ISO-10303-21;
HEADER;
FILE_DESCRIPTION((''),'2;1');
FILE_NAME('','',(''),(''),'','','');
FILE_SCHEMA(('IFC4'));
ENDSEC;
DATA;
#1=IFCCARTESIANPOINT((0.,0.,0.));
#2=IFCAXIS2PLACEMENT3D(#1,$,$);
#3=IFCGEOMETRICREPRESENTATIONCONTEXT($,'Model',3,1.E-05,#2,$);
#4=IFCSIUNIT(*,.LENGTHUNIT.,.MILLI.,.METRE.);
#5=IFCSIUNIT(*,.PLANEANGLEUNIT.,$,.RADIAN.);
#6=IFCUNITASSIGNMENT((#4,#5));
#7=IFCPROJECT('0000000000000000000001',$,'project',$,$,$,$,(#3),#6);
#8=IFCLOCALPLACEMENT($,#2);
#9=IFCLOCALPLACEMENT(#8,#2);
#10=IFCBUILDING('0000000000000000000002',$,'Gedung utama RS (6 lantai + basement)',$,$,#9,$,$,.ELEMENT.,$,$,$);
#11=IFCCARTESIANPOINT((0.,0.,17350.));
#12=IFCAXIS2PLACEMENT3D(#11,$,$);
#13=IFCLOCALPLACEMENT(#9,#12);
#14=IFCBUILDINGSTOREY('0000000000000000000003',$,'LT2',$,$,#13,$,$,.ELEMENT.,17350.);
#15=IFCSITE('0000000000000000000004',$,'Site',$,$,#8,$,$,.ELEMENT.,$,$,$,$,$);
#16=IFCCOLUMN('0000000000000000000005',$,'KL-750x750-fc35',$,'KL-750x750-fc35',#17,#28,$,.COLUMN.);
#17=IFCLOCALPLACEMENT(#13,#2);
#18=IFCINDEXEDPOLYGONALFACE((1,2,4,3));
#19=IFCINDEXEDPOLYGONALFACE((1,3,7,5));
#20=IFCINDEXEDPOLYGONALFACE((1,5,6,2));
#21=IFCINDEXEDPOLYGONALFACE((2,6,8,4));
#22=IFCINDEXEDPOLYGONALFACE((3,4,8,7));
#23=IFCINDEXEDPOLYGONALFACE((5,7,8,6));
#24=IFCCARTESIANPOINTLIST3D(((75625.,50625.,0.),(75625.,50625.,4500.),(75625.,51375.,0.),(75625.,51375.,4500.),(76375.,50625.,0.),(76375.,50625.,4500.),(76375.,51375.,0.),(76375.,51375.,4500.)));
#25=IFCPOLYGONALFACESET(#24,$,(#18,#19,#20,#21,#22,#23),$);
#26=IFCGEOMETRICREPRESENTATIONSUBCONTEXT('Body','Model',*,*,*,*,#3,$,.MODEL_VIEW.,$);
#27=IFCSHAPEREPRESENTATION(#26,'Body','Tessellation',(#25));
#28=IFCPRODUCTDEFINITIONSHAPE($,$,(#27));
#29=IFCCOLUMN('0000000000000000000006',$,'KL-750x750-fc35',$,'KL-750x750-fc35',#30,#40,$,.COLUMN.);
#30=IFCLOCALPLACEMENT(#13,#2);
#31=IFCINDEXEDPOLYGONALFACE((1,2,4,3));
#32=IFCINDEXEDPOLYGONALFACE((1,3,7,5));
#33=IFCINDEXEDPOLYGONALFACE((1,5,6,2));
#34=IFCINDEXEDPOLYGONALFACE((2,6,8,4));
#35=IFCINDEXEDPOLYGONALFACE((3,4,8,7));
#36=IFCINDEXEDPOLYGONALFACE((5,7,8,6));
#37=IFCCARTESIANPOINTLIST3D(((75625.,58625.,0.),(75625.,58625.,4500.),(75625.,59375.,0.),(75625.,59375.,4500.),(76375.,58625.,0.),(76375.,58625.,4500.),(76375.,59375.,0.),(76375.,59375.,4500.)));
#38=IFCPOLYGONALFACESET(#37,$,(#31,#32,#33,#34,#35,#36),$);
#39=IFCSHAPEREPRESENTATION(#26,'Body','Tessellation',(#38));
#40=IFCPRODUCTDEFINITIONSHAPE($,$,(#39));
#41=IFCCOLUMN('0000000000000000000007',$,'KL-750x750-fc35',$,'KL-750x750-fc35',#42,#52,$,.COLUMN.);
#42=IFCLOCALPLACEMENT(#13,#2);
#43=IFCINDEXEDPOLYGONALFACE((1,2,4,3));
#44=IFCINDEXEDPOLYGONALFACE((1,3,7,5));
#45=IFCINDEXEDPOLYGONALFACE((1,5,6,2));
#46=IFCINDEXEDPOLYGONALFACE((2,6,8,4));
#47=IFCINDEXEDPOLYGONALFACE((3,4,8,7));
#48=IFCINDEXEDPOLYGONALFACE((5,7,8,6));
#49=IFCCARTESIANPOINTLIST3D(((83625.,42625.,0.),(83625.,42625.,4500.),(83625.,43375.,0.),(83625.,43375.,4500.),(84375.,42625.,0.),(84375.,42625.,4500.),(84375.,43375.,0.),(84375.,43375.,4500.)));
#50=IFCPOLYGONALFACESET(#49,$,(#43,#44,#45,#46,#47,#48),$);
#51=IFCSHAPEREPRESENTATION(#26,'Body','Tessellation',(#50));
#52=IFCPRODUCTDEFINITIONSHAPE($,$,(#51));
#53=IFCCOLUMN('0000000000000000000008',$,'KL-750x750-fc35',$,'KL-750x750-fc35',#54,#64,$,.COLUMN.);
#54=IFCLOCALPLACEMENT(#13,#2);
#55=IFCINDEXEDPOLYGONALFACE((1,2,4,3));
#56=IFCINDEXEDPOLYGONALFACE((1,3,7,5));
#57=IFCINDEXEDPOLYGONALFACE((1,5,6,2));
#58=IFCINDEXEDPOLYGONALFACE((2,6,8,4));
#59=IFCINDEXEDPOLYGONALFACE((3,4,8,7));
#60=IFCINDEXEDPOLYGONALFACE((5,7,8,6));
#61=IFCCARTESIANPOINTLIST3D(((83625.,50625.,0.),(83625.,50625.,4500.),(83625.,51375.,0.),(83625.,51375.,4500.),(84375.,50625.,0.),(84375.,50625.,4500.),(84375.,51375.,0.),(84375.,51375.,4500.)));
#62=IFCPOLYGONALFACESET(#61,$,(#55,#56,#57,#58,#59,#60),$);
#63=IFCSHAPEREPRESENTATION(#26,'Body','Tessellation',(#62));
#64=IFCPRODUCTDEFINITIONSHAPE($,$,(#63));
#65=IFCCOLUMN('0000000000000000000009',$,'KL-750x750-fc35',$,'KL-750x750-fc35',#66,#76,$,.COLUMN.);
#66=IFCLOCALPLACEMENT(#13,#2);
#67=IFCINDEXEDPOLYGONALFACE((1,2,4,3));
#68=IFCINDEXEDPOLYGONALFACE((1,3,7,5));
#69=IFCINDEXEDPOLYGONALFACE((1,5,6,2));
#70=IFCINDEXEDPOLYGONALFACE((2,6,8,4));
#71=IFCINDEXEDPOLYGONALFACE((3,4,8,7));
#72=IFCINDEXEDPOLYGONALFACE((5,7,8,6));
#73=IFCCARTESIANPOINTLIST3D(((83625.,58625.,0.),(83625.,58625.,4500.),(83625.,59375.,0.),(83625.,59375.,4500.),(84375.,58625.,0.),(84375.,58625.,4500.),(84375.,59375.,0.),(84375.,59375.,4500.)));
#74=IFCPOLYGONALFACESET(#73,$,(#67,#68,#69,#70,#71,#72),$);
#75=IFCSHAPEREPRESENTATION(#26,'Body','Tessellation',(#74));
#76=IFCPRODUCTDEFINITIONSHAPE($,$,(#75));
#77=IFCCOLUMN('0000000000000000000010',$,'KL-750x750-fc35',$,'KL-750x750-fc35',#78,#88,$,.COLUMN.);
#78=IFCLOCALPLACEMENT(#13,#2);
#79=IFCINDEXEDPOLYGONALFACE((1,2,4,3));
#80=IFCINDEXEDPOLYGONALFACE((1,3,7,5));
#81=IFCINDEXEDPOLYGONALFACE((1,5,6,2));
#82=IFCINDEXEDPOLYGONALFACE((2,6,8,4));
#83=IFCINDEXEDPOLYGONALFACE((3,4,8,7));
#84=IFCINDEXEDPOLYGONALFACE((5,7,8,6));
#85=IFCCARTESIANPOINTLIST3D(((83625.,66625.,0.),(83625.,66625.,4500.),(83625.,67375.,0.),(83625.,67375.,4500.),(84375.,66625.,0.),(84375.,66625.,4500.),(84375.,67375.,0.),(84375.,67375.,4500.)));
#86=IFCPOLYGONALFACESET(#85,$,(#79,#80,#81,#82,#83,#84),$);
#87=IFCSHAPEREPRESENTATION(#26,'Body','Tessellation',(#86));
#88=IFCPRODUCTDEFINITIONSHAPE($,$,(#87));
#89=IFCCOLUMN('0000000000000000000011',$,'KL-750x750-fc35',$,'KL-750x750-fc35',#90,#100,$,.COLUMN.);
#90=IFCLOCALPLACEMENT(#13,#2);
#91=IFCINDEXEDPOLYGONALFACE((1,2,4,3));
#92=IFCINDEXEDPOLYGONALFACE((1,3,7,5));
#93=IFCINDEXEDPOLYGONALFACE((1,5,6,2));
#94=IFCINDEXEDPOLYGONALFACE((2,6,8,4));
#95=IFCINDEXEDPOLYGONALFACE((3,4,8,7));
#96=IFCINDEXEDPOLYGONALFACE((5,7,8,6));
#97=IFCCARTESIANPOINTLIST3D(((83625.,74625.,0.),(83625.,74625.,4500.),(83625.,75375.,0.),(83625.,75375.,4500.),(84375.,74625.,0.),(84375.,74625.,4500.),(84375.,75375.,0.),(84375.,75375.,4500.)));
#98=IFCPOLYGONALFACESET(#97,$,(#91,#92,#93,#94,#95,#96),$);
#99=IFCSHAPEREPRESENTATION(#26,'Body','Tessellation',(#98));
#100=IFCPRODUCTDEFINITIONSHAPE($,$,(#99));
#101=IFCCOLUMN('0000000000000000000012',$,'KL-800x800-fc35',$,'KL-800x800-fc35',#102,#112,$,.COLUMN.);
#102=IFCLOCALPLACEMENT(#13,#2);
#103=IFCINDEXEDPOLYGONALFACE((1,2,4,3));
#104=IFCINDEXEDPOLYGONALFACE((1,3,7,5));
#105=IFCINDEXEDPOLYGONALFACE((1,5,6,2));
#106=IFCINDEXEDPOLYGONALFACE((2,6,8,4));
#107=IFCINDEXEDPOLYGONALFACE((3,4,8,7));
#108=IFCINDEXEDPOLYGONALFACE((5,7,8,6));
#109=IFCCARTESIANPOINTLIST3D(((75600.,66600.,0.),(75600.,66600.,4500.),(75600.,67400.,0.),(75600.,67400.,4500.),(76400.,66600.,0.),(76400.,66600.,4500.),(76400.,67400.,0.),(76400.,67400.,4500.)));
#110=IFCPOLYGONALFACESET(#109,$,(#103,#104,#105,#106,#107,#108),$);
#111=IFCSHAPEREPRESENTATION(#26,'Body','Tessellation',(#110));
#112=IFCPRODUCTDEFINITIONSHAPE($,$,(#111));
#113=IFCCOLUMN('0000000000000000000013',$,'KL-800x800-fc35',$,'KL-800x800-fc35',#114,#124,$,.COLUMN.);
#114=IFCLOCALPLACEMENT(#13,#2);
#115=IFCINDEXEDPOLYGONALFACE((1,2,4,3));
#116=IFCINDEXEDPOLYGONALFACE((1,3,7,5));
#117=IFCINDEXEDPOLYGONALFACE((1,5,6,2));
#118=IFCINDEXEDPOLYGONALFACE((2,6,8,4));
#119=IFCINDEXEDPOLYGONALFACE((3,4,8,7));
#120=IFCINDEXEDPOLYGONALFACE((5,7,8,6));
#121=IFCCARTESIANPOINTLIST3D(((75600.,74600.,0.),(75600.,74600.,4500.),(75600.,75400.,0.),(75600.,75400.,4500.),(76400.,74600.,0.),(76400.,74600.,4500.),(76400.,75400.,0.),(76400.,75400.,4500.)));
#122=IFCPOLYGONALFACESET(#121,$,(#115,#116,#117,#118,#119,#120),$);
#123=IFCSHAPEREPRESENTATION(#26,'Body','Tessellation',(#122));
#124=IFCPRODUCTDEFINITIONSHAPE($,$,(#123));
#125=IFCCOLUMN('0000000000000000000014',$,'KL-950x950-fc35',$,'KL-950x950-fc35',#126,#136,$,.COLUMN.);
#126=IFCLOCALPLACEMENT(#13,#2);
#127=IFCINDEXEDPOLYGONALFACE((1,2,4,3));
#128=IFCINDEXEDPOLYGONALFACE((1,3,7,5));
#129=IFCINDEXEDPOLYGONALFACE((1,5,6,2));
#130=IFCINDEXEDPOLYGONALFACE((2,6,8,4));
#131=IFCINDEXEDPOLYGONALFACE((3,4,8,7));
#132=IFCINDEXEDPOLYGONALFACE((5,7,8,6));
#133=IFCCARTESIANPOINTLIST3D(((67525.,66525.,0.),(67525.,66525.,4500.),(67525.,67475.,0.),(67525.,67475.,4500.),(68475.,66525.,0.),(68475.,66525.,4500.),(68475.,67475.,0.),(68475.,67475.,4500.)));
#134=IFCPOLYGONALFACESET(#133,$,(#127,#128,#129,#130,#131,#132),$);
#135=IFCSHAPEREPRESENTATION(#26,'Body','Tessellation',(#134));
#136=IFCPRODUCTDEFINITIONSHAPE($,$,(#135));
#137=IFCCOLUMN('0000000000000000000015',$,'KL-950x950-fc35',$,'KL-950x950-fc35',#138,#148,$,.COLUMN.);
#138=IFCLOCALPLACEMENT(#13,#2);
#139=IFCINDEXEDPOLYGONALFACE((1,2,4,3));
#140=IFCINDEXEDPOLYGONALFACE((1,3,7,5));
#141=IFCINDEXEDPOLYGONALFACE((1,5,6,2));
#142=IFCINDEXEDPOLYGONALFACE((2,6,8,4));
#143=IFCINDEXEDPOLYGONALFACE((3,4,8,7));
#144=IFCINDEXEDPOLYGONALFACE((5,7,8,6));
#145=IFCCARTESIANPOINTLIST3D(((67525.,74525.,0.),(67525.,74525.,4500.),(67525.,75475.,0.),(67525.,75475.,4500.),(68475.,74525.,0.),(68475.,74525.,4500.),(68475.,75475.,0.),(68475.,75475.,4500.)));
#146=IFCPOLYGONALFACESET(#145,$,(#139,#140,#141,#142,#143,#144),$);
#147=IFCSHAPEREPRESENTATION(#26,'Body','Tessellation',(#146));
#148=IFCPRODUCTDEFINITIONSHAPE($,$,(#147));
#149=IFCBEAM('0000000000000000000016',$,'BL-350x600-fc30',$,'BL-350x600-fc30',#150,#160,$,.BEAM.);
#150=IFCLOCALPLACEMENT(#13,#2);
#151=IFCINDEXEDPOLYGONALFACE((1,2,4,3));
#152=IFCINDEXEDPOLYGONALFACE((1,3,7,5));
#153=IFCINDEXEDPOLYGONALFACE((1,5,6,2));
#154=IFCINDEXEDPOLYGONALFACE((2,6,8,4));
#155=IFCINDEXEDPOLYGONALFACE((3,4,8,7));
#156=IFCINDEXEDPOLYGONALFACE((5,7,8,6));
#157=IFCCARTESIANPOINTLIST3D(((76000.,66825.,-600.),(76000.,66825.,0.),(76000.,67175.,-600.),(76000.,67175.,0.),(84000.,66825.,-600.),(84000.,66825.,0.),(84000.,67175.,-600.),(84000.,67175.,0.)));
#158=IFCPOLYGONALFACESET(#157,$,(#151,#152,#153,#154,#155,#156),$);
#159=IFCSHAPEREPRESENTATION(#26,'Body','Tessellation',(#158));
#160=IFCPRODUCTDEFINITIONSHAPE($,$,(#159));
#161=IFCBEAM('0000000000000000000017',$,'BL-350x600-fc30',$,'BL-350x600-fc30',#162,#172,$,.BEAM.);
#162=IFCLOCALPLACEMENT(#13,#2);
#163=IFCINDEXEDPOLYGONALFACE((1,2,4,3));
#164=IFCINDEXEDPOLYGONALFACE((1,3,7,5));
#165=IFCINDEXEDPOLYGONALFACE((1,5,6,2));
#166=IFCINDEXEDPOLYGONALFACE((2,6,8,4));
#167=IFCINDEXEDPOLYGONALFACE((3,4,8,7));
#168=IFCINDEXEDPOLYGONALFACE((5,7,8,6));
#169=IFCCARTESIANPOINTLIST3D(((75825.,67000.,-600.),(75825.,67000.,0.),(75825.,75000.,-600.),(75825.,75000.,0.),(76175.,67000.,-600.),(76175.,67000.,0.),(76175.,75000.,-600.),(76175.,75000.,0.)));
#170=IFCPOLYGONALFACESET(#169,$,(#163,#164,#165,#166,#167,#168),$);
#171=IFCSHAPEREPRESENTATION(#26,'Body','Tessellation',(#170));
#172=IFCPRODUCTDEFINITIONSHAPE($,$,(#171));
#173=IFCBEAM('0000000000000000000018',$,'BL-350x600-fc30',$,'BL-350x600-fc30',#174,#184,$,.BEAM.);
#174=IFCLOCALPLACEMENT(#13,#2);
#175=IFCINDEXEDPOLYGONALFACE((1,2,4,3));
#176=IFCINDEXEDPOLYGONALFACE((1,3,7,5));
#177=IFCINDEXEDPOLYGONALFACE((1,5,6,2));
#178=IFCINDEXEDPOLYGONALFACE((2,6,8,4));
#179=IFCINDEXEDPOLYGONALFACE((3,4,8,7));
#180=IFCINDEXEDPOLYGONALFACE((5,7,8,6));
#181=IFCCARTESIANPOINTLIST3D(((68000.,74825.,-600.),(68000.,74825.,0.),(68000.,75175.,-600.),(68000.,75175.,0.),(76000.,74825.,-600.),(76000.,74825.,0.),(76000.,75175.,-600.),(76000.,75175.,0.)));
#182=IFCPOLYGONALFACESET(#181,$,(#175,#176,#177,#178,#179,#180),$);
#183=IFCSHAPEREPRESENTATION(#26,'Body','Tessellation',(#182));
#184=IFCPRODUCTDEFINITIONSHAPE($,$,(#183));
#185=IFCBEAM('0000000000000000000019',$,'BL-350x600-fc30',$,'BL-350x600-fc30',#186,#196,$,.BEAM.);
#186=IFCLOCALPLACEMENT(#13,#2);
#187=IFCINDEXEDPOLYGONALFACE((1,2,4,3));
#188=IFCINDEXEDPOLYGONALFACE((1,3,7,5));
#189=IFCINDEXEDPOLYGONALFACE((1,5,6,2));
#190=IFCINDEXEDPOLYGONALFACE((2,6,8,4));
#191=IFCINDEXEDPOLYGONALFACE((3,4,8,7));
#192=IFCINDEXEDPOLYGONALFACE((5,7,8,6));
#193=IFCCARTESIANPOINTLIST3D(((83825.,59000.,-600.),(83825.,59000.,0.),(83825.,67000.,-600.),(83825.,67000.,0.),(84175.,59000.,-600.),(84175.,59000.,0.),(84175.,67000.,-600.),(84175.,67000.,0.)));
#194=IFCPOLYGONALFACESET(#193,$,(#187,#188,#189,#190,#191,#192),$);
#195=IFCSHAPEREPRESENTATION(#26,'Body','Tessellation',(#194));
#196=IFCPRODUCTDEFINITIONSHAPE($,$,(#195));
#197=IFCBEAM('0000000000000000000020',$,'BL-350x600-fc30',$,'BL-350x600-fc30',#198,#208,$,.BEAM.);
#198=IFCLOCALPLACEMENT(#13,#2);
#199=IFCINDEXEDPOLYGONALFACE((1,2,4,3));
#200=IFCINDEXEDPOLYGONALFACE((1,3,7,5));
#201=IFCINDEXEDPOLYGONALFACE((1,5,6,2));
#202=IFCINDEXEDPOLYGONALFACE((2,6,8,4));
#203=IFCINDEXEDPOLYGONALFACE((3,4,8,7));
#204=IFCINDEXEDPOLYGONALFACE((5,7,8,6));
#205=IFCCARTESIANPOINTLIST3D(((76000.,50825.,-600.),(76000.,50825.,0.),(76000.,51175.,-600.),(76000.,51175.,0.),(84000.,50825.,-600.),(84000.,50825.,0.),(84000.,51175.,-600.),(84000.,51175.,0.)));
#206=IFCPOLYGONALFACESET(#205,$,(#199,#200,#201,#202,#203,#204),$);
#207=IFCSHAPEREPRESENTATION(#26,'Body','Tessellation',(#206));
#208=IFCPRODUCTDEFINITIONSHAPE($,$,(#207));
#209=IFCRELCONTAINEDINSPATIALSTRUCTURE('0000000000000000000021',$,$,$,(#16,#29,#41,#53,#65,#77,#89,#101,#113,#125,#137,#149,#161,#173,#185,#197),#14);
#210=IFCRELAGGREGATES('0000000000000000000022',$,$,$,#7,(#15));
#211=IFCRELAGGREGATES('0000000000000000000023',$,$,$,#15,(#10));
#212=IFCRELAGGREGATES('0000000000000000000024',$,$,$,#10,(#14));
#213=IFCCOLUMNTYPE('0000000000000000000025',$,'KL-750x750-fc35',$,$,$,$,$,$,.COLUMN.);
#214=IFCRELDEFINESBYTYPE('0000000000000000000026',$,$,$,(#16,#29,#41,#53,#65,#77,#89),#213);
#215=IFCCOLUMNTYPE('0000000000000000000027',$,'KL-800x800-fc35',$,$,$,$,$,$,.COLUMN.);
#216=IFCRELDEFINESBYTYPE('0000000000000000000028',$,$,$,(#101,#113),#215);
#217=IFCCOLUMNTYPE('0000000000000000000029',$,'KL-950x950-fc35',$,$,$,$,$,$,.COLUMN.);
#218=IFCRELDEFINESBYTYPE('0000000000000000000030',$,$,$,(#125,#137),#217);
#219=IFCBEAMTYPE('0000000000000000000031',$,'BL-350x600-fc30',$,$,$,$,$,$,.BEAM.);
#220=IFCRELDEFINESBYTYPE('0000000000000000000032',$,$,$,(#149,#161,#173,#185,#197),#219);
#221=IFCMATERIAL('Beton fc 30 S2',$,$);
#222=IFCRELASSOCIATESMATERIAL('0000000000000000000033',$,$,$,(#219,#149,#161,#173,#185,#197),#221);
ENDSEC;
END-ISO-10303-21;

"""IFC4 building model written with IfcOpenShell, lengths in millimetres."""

from ifc_helpers import new_model, si_unit, frame, origin, origin_2d, place, context, subcontext, project, spatial, rectangle, extrude, material, material_profile, profile_set, profile_usage, type_object, element, save


model = new_model("IFC4")

# Units and contexts
model_context = context("Model", 3, precision=1e-05, world=origin())
body_context = subcontext(model_context, "Body", "Model", "MODEL_VIEW")
ifc_project = project(units=[si_unit("LENGTHUNIT", "METRE", prefix="MILLI"), si_unit("PLANEANGLEUNIT", "RADIAN")], contexts=[model_context])

# Site, building, storey
site_placement = place(None, origin())
site = spatial("IfcSite", under=ifc_project, at=site_placement, Name="Site", CompositionType="ELEMENT")
building_placement = place(site_placement, origin())
building = spatial("IfcBuilding", under=site, at=building_placement, Name="Gedung utama RS (6 lantai + basement)", CompositionType="ELEMENT")
storey_placement = place(building_placement, frame((0.0, 0.0, 17350.0)))
storey = spatial("IfcBuildingStorey", under=building, at=storey_placement, Name="LT2", CompositionType="ELEMENT", Elevation=17350.0)

# Columns
ifc_material_profile_1 = material_profile(None, rectangle(XDim=750.0, YDim=750.0, at=origin_2d()), Name="KL-750x750-fc35")
ifc_profile_set_1 = profile_set([ifc_material_profile_1], Name="KL-750x750-fc35")
ifc_profile_usage_1 = profile_usage(ifc_profile_set_1, cardinal=5)
column_type_1 = type_object("IfcColumnType", Name="KL-750x750-fc35", PredefinedType="COLUMN", material=ifc_profile_set_1)
for number, where, z_axis, x_axis, name in (
    (1, (76000.0, 51000.0, 0.0), (0.0, 0.0, 1.0), (1.0, 0.0, 0.0), "KL-750x750-fc35"),
    (2, (76000.0, 59000.0, 0.0), (0.0, 0.0, 1.0), (1.0, 0.0, 0.0), "KL-750x750-fc35"),
    (3, (84000.0, 43000.0, 0.0), (0.0, 0.0, 1.0), (1.0, 0.0, 0.0), "KL-750x750-fc35"),
    (4, (84000.0, 51000.0, 0.0), (0.0, 0.0, 1.0), (1.0, 0.0, 0.0), "KL-750x750-fc35"),
    (5, (84000.0, 59000.0, 0.0), (0.0, 0.0, 1.0), (1.0, 0.0, 0.0), "KL-750x750-fc35"),
    (6, (84000.0, 67000.0, 0.0), (0.0, 0.0, 1.0), (1.0, 0.0, 0.0), "KL-750x750-fc35"),
    (7, (84000.0, 75000.0, 0.0), (0.0, 0.0, 1.0), (1.0, 0.0, 0.0), "KL-750x750-fc35"),
):
    element("IfcColumn", number, at=place(storey_placement, frame(where, z_axis=z_axis, x_axis=x_axis)), inside=storey, type_object=column_type_1, material=ifc_profile_usage_1, Name=name, ObjectType="KL-750x750-fc35", PredefinedType="COLUMN", context=body_context, shape_type="SweptSolid", body=[
        extrude(rectangle(XDim=750.0, YDim=750.0, at=origin_2d()), origin(), (0.0, 0.0, 1.0), 4500.0),
    ])
ifc_material_profile_2 = material_profile(None, rectangle(XDim=800.0, YDim=800.0, at=origin_2d()), Name="KL-800x800-fc35")
ifc_profile_set_2 = profile_set([ifc_material_profile_2], Name="KL-800x800-fc35")
ifc_profile_usage_2 = profile_usage(ifc_profile_set_2, cardinal=5)
column_type_2 = type_object("IfcColumnType", Name="KL-800x800-fc35", PredefinedType="COLUMN", material=ifc_profile_set_2)
for number, where, z_axis, x_axis, name in (
    (8, (76000.0, 67000.0, 0.0), (0.0, 0.0, 1.0), (1.0, 0.0, 0.0), "KL-800x800-fc35"),
    (9, (76000.0, 75000.0, 0.0), (0.0, 0.0, 1.0), (1.0, 0.0, 0.0), "KL-800x800-fc35"),
):
    element("IfcColumn", number, at=place(storey_placement, frame(where, z_axis=z_axis, x_axis=x_axis)), inside=storey, type_object=column_type_2, material=ifc_profile_usage_2, Name=name, ObjectType="KL-800x800-fc35", PredefinedType="COLUMN", context=body_context, shape_type="SweptSolid", body=[
        extrude(rectangle(XDim=800.0, YDim=800.0, at=origin_2d()), origin(), (0.0, 0.0, 1.0), 4500.0),
    ])
ifc_material_profile_3 = material_profile(None, rectangle(XDim=950.0, YDim=950.0, at=origin_2d()), Name="KL-950x950-fc35")
ifc_profile_set_3 = profile_set([ifc_material_profile_3], Name="KL-950x950-fc35")
ifc_profile_usage_3 = profile_usage(ifc_profile_set_3, cardinal=5)
column_type_3 = type_object("IfcColumnType", Name="KL-950x950-fc35", PredefinedType="COLUMN", material=ifc_profile_set_3)
for number, where, z_axis, x_axis, name in (
    (10, (68000.0, 67000.0, 0.0), (0.0, 0.0, 1.0), (1.0, 0.0, 0.0), "KL-950x950-fc35"),
    (11, (68000.0, 75000.0, 0.0), (0.0, 0.0, 1.0), (1.0, 0.0, 0.0), "KL-950x950-fc35"),
):
    element("IfcColumn", number, at=place(storey_placement, frame(where, z_axis=z_axis, x_axis=x_axis)), inside=storey, type_object=column_type_3, material=ifc_profile_usage_3, Name=name, ObjectType="KL-950x950-fc35", PredefinedType="COLUMN", context=body_context, shape_type="SweptSolid", body=[
        extrude(rectangle(XDim=950.0, YDim=950.0, at=origin_2d()), origin(), (0.0, 0.0, 1.0), 4500.0),
    ])

# Beams
ifc_material_1 = material(Name="Beton fc 30 S2")
ifc_material_profile_4 = material_profile(ifc_material_1, rectangle(XDim=350.0, YDim=600.0, at=origin_2d()), Name="BL-350x600-fc30")
ifc_profile_set_4 = profile_set([ifc_material_profile_4], Name="BL-350x600-fc30")
ifc_profile_usage_4 = profile_usage(ifc_profile_set_4, cardinal=8)
beam_type = type_object("IfcBeamType", Name="BL-350x600-fc30", PredefinedType="BEAM", material=ifc_profile_set_4)
beam_1_placement = place(storey_placement, frame((76000.0, 67000.0, -300.0)))
element("IfcBeam", 12, at=beam_1_placement, inside=storey, type_object=beam_type, material=ifc_profile_usage_4, Name="BL-350x600-fc30", ObjectType="BL-350x600-fc30", PredefinedType="BEAM", context=body_context, shape_type="SweptSolid", body=[
    extrude(rectangle(XDim=350.0, YDim=600.0, at=origin_2d()), frame((0.0, 0.0, 0.0), z_axis=(1.0, 0.0, 0.0), x_axis=(0.0, 1.0, 0.0)), (0.0, 0.0, 1.0), 8000.0),
])
beam_2_placement = place(storey_placement, frame((76000.0, 67000.0, -300.0)))
element("IfcBeam", 13, at=beam_2_placement, inside=storey, type_object=beam_type, material=ifc_profile_usage_4, Name="BL-350x600-fc30", ObjectType="BL-350x600-fc30", PredefinedType="BEAM", context=body_context, shape_type="SweptSolid", body=[
    extrude(rectangle(XDim=350.0, YDim=600.0, at=origin_2d()), frame((0.0, 0.0, 0.0), z_axis=(0.0, 1.0, 0.0), x_axis=(-1.0, 0.0, 0.0)), (0.0, 0.0, 1.0), 8000.0),
])
beam_3_placement = place(storey_placement, frame((68000.0, 75000.0, -300.0)))
element("IfcBeam", 14, at=beam_3_placement, inside=storey, type_object=beam_type, material=ifc_profile_usage_4, Name="BL-350x600-fc30", ObjectType="BL-350x600-fc30", PredefinedType="BEAM", context=body_context, shape_type="SweptSolid", body=[
    extrude(rectangle(XDim=350.0, YDim=600.0, at=origin_2d()), frame((0.0, 0.0, 0.0), z_axis=(1.0, 0.0, 0.0), x_axis=(0.0, 1.0, 0.0)), (0.0, 0.0, 1.0), 8000.0),
])
beam_4_placement = place(storey_placement, frame((84000.0, 59000.0, -300.0)))
element("IfcBeam", 15, at=beam_4_placement, inside=storey, type_object=beam_type, material=ifc_profile_usage_4, Name="BL-350x600-fc30", ObjectType="BL-350x600-fc30", PredefinedType="BEAM", context=body_context, shape_type="SweptSolid", body=[
    extrude(rectangle(XDim=350.0, YDim=600.0, at=origin_2d()), frame((0.0, 0.0, 0.0), z_axis=(0.0, 1.0, 0.0), x_axis=(-1.0, 0.0, 0.0)), (0.0, 0.0, 1.0), 8000.0),
])
beam_5_placement = place(storey_placement, frame((76000.0, 51000.0, -300.0)))
element("IfcBeam", 16, at=beam_5_placement, inside=storey, type_object=beam_type, material=ifc_profile_usage_4, Name="BL-350x600-fc30", ObjectType="BL-350x600-fc30", PredefinedType="BEAM", context=body_context, shape_type="SweptSolid", body=[
    extrude(rectangle(XDim=350.0, YDim=600.0, at=origin_2d()), frame((0.0, 0.0, 0.0), z_axis=(1.0, 0.0, 0.0), x_axis=(0.0, 1.0, 0.0)), (0.0, 0.0, 1.0), 8000.0),
])

save(model, "model.ifc")
